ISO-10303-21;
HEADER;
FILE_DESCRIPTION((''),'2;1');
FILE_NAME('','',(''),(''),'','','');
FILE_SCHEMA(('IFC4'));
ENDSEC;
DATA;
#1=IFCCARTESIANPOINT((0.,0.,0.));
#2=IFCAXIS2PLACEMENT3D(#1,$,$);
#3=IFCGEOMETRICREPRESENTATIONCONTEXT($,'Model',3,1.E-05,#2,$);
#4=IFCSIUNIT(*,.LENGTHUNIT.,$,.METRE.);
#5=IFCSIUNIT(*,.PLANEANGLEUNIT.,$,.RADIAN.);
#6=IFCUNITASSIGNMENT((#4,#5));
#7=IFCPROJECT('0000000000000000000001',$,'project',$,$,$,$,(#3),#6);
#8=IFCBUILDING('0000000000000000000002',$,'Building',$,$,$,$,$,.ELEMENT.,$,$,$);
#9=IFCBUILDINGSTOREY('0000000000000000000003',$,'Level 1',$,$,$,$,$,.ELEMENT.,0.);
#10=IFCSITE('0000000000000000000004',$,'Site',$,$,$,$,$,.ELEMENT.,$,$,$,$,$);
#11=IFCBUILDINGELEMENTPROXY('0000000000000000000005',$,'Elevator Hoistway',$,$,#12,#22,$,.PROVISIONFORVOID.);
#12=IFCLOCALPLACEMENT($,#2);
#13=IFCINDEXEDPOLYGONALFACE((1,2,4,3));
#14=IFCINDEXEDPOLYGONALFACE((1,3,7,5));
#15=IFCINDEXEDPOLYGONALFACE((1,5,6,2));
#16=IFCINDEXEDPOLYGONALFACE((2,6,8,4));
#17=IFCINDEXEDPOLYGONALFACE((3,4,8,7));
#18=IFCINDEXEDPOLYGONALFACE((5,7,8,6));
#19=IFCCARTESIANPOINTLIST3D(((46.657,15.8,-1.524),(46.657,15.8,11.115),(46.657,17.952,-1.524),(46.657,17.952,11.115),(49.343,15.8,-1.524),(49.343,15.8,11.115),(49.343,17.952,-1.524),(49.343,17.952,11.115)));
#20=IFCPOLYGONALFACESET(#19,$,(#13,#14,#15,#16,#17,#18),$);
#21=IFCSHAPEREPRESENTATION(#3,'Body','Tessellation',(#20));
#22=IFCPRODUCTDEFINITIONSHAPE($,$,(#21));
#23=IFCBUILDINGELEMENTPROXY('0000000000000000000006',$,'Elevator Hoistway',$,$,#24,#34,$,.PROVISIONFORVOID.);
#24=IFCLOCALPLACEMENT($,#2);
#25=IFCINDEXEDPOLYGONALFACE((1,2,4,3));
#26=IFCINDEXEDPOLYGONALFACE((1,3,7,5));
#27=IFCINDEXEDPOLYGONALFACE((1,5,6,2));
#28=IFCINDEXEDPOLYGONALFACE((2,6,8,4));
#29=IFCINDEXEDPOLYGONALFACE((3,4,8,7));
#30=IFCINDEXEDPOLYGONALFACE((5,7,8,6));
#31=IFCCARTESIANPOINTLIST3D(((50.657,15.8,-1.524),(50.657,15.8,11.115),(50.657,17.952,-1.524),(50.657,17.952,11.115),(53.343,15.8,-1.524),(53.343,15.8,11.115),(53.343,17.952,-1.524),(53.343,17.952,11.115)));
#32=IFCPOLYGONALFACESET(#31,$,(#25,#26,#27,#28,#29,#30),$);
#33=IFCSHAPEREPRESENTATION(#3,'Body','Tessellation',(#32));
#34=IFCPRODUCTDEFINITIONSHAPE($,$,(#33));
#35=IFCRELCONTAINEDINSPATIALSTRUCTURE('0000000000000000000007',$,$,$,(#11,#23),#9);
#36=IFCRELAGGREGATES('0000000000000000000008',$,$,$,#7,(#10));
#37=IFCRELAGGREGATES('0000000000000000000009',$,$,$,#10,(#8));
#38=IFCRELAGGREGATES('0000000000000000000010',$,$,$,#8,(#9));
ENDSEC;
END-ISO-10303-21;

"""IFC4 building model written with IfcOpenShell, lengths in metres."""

from ifc_helpers import new_model, si_unit, frame, origin, place, context, project, spatial, polyline, outline, extrude, element, save


model = new_model("IFC4")

# Units and contexts
model_context = context("Model", 3, precision=1e-05, world=origin())
ifc_project = project(units=[si_unit("LENGTHUNIT", "METRE"), si_unit("PLANEANGLEUNIT", "RADIAN")], contexts=[model_context])

# Site, building, storey
site = spatial("IfcSite", under=ifc_project, Name="Site", CompositionType="ELEMENT")
building = spatial("IfcBuilding", under=site, Name="Building", CompositionType="ELEMENT")
storey = spatial("IfcBuildingStorey", under=building, Name="Level 1", CompositionType="ELEMENT", Elevation=0.0)

# Building element proxies
proxy_1_placement = place(None, frame((0.0, 0.0, 11.115)))
element("IfcBuildingElementProxy", 1, at=proxy_1_placement, inside=storey, Name="Elevator Hoistway", PredefinedType="PROVISIONFORVOID", context=model_context, shape_type="SweptSolid", body=[
    extrude(outline(polyline([(46.657, 15.8), (49.343, 15.8), (49.343, 17.952), (46.657, 17.952), (46.657, 15.8)])), origin(), (0.0, 0.0, -1.0), 12.639),
])
proxy_2_placement = place(None, frame((0.0, 0.0, 11.115)))
element("IfcBuildingElementProxy", 2, at=proxy_2_placement, inside=storey, Name="Elevator Hoistway", PredefinedType="PROVISIONFORVOID", context=model_context, shape_type="SweptSolid", body=[
    extrude(outline(polyline([(50.657, 15.8), (53.343, 15.8), (53.343, 17.952), (50.657, 17.952), (50.657, 15.8)])), origin(), (0.0, 0.0, -1.0), 12.639),
])

save(model, "model.ifc")
